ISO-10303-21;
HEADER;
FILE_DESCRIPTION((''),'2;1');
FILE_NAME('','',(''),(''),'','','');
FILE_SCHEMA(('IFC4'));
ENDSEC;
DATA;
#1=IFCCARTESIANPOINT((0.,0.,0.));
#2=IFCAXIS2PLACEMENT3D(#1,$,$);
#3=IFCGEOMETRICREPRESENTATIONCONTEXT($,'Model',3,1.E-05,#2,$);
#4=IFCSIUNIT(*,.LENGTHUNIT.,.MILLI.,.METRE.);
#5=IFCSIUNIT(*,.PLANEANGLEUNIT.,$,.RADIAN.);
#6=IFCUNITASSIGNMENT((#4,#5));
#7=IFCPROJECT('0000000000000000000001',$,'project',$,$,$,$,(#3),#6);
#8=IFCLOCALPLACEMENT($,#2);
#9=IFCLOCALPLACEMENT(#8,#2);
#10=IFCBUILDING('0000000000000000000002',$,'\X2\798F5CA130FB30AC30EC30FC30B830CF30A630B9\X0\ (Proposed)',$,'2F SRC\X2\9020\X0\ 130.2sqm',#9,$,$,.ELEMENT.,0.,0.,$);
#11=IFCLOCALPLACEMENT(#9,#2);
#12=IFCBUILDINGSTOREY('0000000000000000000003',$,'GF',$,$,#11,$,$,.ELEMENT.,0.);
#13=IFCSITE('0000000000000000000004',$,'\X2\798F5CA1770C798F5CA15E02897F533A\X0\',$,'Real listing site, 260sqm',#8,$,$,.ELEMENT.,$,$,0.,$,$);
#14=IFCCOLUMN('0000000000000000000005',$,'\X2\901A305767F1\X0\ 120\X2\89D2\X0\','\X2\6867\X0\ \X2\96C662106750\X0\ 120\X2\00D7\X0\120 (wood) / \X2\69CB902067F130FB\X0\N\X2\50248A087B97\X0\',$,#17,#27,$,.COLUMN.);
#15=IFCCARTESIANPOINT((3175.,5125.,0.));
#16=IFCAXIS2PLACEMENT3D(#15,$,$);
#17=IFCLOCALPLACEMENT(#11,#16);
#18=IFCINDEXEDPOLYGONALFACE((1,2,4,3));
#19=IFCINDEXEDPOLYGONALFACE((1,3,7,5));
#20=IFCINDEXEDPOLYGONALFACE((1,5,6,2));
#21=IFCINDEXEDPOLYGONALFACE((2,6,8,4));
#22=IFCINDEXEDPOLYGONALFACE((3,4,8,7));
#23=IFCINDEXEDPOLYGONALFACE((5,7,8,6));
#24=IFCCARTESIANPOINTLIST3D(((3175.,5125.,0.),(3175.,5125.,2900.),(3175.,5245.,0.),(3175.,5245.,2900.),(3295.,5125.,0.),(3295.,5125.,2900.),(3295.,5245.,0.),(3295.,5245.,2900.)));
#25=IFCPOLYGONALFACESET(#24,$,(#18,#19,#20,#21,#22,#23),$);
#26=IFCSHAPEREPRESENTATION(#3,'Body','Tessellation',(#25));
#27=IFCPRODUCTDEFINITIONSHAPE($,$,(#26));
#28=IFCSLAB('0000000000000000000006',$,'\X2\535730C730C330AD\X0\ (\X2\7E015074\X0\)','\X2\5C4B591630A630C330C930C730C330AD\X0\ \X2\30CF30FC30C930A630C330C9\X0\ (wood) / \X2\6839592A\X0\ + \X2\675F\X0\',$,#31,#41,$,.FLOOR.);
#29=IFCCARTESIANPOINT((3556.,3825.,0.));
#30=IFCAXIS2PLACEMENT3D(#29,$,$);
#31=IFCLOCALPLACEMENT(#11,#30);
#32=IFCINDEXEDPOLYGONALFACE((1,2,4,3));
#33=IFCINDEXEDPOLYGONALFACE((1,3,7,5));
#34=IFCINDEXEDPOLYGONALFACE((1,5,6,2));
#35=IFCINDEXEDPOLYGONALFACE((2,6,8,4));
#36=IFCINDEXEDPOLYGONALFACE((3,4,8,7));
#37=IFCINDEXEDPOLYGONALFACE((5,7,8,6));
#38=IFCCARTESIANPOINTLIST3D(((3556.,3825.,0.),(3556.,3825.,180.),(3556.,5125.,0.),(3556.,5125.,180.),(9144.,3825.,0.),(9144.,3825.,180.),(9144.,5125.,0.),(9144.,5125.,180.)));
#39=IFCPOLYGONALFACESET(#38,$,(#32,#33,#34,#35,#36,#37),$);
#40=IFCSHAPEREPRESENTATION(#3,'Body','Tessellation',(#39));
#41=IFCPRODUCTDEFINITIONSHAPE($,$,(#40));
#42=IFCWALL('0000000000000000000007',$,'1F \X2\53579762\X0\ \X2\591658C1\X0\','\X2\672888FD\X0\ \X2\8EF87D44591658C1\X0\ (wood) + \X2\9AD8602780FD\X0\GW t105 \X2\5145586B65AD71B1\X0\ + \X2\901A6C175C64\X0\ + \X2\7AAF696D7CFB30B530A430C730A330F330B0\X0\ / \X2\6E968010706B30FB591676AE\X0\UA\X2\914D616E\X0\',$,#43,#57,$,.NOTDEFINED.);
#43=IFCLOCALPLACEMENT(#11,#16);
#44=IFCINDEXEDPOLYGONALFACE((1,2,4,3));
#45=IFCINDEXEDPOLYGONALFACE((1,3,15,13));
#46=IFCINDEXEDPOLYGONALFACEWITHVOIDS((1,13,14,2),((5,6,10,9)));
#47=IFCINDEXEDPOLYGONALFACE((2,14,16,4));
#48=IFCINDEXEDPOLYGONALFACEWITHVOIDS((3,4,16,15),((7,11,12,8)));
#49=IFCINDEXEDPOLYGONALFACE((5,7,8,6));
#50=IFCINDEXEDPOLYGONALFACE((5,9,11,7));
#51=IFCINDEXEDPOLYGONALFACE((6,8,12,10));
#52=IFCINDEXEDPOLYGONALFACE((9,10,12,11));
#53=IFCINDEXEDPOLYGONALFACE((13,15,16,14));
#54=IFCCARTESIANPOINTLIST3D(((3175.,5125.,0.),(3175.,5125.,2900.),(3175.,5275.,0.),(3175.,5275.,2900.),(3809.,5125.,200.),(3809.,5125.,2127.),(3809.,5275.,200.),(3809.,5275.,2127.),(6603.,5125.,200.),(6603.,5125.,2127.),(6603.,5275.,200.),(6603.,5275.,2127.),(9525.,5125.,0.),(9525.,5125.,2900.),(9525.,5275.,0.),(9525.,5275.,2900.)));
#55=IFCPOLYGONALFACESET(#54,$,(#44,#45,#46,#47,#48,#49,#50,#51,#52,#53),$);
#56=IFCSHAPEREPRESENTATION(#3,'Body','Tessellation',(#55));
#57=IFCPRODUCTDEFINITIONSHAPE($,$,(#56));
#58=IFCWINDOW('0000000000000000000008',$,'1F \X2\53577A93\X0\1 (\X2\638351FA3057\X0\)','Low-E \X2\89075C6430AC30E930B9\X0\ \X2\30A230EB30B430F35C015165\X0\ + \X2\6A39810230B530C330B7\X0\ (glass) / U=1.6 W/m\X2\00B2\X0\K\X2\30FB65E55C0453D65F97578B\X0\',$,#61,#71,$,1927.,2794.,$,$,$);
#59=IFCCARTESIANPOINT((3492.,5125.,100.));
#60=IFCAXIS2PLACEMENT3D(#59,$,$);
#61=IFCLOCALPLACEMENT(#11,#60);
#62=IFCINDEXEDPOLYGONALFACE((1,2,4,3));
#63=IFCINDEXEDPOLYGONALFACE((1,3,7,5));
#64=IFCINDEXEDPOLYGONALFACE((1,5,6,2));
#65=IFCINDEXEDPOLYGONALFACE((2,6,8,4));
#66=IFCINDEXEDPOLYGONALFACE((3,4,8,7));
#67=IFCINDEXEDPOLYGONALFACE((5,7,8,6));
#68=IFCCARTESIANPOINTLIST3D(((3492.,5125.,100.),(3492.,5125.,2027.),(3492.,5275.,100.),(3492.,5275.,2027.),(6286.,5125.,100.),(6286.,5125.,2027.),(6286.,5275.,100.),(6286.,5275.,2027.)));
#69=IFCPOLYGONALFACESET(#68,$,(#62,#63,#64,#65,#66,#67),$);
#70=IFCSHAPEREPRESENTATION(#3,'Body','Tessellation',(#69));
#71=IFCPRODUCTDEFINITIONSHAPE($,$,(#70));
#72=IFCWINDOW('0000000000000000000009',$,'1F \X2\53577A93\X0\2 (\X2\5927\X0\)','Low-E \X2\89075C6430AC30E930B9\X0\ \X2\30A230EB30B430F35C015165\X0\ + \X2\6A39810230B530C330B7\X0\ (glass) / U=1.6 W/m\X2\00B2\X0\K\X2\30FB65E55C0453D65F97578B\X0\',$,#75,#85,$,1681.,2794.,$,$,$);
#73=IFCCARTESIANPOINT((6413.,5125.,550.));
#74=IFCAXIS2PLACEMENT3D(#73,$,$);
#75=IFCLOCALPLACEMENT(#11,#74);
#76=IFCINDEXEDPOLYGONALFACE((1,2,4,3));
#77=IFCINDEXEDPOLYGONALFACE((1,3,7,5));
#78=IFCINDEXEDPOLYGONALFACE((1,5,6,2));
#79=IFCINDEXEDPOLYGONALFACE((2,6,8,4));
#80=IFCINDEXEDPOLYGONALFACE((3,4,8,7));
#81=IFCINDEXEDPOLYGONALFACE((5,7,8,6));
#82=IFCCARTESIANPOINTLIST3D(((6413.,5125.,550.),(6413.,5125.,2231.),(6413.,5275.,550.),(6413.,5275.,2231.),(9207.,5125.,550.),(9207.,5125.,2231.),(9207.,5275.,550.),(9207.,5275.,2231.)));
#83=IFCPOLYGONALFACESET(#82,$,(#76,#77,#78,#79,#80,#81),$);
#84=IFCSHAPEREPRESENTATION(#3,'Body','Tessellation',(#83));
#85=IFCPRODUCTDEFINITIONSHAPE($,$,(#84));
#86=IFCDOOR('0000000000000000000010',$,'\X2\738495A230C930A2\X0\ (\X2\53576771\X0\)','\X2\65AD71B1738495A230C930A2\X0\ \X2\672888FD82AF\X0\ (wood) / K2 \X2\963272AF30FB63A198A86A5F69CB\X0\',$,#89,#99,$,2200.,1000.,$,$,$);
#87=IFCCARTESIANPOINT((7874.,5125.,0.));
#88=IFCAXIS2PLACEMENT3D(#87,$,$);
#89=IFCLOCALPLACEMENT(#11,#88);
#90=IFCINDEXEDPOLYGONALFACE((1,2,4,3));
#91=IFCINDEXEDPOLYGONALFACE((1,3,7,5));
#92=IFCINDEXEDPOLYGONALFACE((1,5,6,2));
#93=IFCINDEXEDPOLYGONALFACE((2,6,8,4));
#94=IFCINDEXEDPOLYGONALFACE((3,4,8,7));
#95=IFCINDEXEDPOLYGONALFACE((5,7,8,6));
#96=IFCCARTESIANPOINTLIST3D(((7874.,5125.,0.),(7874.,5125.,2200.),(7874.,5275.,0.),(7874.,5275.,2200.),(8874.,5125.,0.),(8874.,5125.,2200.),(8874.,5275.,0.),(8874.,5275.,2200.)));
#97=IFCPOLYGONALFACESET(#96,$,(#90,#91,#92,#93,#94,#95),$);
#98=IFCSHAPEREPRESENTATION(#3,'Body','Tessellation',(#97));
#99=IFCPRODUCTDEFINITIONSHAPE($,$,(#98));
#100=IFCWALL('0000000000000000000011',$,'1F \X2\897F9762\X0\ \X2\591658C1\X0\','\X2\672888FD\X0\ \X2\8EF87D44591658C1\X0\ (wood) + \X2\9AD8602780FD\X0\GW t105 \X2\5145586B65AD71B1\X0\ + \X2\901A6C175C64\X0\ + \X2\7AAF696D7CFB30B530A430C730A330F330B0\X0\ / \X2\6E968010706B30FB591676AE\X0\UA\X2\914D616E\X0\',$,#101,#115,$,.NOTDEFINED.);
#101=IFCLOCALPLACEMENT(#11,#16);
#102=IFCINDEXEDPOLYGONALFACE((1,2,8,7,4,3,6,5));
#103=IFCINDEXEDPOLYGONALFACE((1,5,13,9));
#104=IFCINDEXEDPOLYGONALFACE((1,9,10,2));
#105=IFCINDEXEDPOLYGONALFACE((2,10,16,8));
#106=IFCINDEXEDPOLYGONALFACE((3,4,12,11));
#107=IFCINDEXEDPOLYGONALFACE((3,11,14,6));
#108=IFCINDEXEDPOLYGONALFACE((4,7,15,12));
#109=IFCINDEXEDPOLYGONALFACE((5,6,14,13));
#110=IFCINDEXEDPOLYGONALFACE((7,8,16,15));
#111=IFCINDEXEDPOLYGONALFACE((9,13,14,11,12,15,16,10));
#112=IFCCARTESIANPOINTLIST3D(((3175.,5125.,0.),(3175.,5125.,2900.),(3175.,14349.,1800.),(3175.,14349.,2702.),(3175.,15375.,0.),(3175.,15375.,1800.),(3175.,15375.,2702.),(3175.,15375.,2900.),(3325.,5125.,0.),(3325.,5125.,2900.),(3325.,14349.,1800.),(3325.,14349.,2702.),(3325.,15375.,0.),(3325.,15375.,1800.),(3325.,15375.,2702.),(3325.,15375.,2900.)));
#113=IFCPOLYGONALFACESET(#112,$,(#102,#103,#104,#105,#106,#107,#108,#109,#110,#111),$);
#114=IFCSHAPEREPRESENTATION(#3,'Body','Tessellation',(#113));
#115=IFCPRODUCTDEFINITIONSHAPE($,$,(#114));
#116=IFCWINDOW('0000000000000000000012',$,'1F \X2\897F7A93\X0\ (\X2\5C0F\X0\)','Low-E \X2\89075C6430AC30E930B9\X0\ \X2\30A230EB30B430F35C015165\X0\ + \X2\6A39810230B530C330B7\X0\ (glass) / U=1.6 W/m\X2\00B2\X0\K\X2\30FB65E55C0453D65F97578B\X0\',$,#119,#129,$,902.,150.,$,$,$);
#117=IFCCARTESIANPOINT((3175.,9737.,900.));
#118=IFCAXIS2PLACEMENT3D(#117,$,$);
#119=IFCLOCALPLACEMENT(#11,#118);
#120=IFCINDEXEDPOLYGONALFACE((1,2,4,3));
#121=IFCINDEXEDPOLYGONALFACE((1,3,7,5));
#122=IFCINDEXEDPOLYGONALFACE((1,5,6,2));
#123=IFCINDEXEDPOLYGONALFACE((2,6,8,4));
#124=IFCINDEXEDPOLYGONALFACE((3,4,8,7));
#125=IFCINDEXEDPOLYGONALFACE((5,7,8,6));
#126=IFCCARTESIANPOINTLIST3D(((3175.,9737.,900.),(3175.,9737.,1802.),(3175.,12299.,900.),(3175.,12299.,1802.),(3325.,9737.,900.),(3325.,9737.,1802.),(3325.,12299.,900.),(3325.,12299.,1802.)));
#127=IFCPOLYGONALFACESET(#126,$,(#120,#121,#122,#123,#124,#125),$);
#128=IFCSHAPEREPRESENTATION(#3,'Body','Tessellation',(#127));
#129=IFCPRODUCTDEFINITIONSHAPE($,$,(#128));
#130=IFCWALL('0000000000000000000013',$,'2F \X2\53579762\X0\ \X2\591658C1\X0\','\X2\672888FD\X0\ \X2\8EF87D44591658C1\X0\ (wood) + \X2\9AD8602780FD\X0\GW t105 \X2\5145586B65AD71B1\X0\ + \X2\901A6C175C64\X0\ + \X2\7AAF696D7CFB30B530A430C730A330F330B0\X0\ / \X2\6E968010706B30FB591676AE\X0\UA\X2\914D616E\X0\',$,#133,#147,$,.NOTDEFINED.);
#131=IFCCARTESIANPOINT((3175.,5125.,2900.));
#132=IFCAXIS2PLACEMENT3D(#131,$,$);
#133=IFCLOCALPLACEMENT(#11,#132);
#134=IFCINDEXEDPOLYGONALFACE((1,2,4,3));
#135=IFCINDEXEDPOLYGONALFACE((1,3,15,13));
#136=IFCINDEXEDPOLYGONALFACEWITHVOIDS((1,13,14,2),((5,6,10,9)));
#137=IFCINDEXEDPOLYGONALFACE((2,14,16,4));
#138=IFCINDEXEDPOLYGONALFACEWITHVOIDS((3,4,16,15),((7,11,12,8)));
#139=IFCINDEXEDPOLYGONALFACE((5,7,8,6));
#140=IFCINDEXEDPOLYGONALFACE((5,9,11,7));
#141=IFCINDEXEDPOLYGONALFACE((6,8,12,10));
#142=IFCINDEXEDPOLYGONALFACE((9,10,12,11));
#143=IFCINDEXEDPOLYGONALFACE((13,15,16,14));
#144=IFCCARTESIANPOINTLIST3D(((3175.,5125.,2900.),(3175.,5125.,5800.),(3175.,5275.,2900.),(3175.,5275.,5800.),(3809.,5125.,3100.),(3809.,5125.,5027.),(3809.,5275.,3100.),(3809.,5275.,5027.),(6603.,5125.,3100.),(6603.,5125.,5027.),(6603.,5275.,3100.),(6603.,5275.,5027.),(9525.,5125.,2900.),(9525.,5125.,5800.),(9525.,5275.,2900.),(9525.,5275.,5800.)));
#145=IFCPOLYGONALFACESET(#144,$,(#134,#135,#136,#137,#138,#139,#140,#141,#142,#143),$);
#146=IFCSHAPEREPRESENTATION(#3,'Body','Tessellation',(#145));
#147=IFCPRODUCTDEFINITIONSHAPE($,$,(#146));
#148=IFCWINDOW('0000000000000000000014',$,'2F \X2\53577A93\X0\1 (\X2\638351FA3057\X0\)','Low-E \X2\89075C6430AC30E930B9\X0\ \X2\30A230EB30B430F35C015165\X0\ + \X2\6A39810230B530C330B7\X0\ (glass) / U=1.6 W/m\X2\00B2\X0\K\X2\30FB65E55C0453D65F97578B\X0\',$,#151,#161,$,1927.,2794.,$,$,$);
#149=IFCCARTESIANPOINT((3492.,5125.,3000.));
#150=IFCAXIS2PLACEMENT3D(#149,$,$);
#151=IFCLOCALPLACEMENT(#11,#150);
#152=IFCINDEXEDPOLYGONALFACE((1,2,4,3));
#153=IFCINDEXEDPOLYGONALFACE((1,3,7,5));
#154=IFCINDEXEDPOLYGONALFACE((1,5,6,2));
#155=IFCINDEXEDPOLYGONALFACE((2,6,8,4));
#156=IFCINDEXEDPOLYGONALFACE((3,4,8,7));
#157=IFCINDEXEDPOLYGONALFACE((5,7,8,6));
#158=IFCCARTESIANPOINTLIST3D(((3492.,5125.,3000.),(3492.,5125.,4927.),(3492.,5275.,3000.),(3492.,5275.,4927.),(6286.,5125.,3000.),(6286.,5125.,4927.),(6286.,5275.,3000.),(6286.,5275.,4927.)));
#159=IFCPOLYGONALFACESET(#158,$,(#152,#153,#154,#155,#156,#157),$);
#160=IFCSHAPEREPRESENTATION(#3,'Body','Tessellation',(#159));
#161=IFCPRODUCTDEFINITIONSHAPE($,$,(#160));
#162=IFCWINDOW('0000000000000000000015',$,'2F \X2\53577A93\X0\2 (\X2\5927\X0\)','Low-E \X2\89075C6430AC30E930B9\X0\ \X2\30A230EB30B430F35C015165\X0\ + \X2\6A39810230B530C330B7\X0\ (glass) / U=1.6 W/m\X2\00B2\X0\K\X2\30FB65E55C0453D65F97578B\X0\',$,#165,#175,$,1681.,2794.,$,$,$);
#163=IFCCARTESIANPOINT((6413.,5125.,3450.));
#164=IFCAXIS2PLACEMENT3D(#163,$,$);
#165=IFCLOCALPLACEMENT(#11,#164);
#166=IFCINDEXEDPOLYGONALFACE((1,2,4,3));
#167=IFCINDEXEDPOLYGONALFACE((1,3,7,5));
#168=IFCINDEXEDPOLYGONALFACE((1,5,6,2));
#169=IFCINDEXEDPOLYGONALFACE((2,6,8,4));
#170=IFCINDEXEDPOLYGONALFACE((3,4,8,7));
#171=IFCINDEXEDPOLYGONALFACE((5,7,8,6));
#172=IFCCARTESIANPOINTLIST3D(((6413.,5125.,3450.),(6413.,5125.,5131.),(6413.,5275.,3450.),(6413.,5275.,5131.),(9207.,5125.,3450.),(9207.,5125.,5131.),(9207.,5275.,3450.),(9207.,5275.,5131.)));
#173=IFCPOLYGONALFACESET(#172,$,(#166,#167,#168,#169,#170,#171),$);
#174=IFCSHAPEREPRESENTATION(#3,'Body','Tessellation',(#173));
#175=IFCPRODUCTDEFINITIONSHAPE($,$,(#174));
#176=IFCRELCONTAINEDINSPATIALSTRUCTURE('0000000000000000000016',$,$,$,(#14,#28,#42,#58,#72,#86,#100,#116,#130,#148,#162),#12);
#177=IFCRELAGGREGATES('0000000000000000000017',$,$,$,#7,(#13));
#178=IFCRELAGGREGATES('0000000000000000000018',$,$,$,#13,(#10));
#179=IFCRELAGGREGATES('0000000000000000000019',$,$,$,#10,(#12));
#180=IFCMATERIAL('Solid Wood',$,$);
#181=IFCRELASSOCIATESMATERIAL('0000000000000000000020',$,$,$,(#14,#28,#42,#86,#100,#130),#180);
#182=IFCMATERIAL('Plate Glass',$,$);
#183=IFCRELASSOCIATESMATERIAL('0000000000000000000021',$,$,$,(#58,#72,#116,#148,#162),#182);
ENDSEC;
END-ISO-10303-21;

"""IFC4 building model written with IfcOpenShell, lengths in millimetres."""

from ifc_helpers import new_model, si_unit, frame, frame_2d, origin, place, context, project, spatial, rectangle, extrude, material, element, fill, save


model = new_model("IFC4")

# Units and contexts
model_context = context("Model", 3, precision=1e-05, world=origin())
ifc_project = project(units=[si_unit("LENGTHUNIT", "METRE", prefix="MILLI"), si_unit("PLANEANGLEUNIT", "RADIAN")], contexts=[model_context])

# Site, building, storey
site_placement = place(None, origin())
site = spatial("IfcSite", under=ifc_project, at=site_placement, Name="福岡県福岡市西区", ObjectType="Real listing site, 260sqm", CompositionType="ELEMENT", RefElevation=0.0)
building_placement = place(site_placement, origin())
building = spatial("IfcBuilding", under=site, at=building_placement, Name="福岡・ガレージハウス (Proposed)", ObjectType="2F SRC造 130.2sqm", CompositionType="ELEMENT", ElevationOfRefHeight=0.0, ElevationOfTerrain=0.0)
storey_placement = place(building_placement, origin())
storey = spatial("IfcBuildingStorey", under=building, at=storey_placement, Name="GF", CompositionType="ELEMENT", Elevation=0.0)

# Column
ifc_material_1 = material(Name="Solid Wood")
column_placement = place(storey_placement, frame((3175.0, 5125.0, 0.0)))
element("IfcColumn", 1, at=column_placement, inside=storey, material=ifc_material_1, Name="通し柱 120角", Description="桧 集成材 120×120 (wood) / 構造柱・N値計算", PredefinedType="COLUMN", context=model_context, shape_type="SweptSolid", body=[
    extrude(rectangle(XDim=120.0, YDim=120.0, at=frame_2d((60.0, 60.0))), frame((3175.0, 5125.0, 0.0)), (0.0, 0.0, 1.0), 2900.0),
])

# Slab
slab_1_placement = place(storey_placement, frame((3556.0, 3825.0, 0.0)))
element("IfcSlab", 2, at=slab_1_placement, inside=storey, material=ifc_material_1, Name="南デッキ (縁側)", Description="屋外ウッドデッキ ハードウッド (wood) / 根太 + 束", PredefinedType="FLOOR", context=model_context, shape_type="SweptSolid", body=[
    extrude(rectangle(XDim=5588.0, YDim=1300.0, at=frame_2d((2794.0, 650.0))), frame((3556.0, 3825.0, 0.0)), (0.0, 0.0, 1.0), 180.0),
])

# Wall, openings, windows, door
wall_1_placement = place(storey_placement, frame((3175.0, 5125.0, 0.0)))
wall_1 = element("IfcWall", 3, at=wall_1_placement, inside=storey, material=ifc_material_1, Name="1F 南面 外壁", Description="木製 軸組外壁 (wood) + 高性能GW t105 充填断熱 + 通気層 + 窯業系サイディング / 準耐火・外皮UA配慮", PredefinedType="NOTDEFINED", context=model_context, shape_type="SweptSolid", body=[
    extrude(rectangle(XDim=6350.0, YDim=150.0, at=frame_2d((3175.0, 75.0))), frame((3175.0, 5125.0, 0.0)), (0.0, 0.0, 1.0), 2900.0),
])
opening_1_placement = place(storey_placement, frame((3492.0, 5125.0, 100.0)))
opening_1 = element("IfcOpeningElement", 4, at=opening_1_placement, cuts=wall_1, PredefinedType="NOTDEFINED", context=model_context, shape_type="SweptSolid", body=[
    extrude(rectangle(XDim=2794.0, YDim=150.0, at=frame_2d((1397.0, 75.0))), frame((3492.0, 5125.0, 100.0)), (0.0, 0.0, 1.0), 1927.0),
])
opening_2_placement = place(storey_placement, frame((6413.0, 5125.0, 550.0)))
opening_2 = element("IfcOpeningElement", 5, at=opening_2_placement, cuts=wall_1, PredefinedType="NOTDEFINED", context=model_context, shape_type="SweptSolid", body=[
    extrude(rectangle(XDim=2794.0, YDim=150.0, at=frame_2d((1397.0, 75.0))), frame((6413.0, 5125.0, 550.0)), (0.0, 0.0, 1.0), 1681.0),
])
opening_3_placement = place(storey_placement, frame((7874.0, 5125.0, 0.0)))
opening_3 = element("IfcOpeningElement", 6, at=opening_3_placement, cuts=wall_1, PredefinedType="NOTDEFINED", context=model_context, shape_type="SweptSolid", body=[
    extrude(rectangle(XDim=1000.0, YDim=150.0, at=frame_2d((500.0, 75.0))), frame((7874.0, 5125.0, 0.0)), (0.0, 0.0, 1.0), 2200.0),
])
ifc_material_2 = material(Name="Plate Glass")
window_1_placement = place(storey_placement, frame((3492.0, 5125.0, 100.0)))
window_1 = element("IfcWindow", 7, at=window_1_placement, inside=storey, material=ifc_material_2, Name="1F 南窓1 (掃出し)", Description="Low-E 複層ガラス アルゴン封入 + 樹脂サッシ (glass) / U=1.6 W/m²K・日射取得型", OverallHeight=1927.0, OverallWidth=2794.0, context=model_context, shape_type="SweptSolid", body=[
    extrude(rectangle(XDim=2794.0, YDim=150.0, at=frame_2d((1397.0, 75.0))), frame((3492.0, 5125.0, 100.0)), (0.0, 0.0, 1.0), 1927.0),
])
fill(opening_1, window_1)
window_2_placement = place(storey_placement, frame((6413.0, 5125.0, 550.0)))
window_2 = element("IfcWindow", 8, at=window_2_placement, inside=storey, material=ifc_material_2, Name="1F 南窓2 (大)", Description="Low-E 複層ガラス アルゴン封入 + 樹脂サッシ (glass) / U=1.6 W/m²K・日射取得型", OverallHeight=1681.0, OverallWidth=2794.0, context=model_context, shape_type="SweptSolid", body=[
    extrude(rectangle(XDim=2794.0, YDim=150.0, at=frame_2d((1397.0, 75.0))), frame((6413.0, 5125.0, 550.0)), (0.0, 0.0, 1.0), 1681.0),
])
fill(opening_2, window_2)
door_placement = place(storey_placement, frame((7874.0, 5125.0, 0.0)))
door = element("IfcDoor", 9, at=door_placement, inside=storey, material=ifc_material_1, Name="玄関ドア (南東)", Description="断熱玄関ドア 木製芯 (wood) / K2 防犯・採風機構", OverallHeight=2200.0, OverallWidth=1000.0, context=model_context, shape_type="SweptSolid", body=[
    extrude(rectangle(XDim=1000.0, YDim=150.0, at=frame_2d((500.0, 75.0))), frame((7874.0, 5125.0, 0.0)), (0.0, 0.0, 1.0), 2200.0),
])
fill(opening_3, door)

# Wall, opening, window
wall_2_placement = place(storey_placement, frame((3175.0, 5125.0, 0.0)))
wall_2 = element("IfcWall", 10, at=wall_2_placement, inside=storey, material=ifc_material_1, Name="1F 西面 外壁", Description="木製 軸組外壁 (wood) + 高性能GW t105 充填断熱 + 通気層 + 窯業系サイディング / 準耐火・外皮UA配慮", PredefinedType="NOTDEFINED", context=model_context, shape_type="SweptSolid", body=[
    extrude(rectangle(XDim=150.0, YDim=10250.0, at=frame_2d((75.0, 5125.0))), frame((3175.0, 5125.0, 0.0)), (0.0, 0.0, 1.0), 2900.0),
])
opening_4_placement = place(storey_placement, frame((3175.0, 9737.0, 900.0)))
opening_4 = element("IfcOpeningElement", 11, at=opening_4_placement, cuts=wall_2, PredefinedType="NOTDEFINED", context=model_context, shape_type="SweptSolid", body=[
    extrude(rectangle(XDim=150.0, YDim=2562.0, at=frame_2d((75.0, 1281.0))), frame((3175.0, 9737.0, 900.0)), (0.0, 0.0, 1.0), 902.0),
])
window_3_placement = place(storey_placement, frame((3175.0, 9737.0, 900.0)))
window_3 = element("IfcWindow", 12, at=window_3_placement, inside=storey, material=ifc_material_2, Name="1F 西窓 (小)", Description="Low-E 複層ガラス アルゴン封入 + 樹脂サッシ (glass) / U=1.6 W/m²K・日射取得型", OverallHeight=902.0, OverallWidth=150.0, context=model_context, shape_type="SweptSolid", body=[
    extrude(rectangle(XDim=150.0, YDim=2562.0, at=frame_2d((75.0, 1281.0))), frame((3175.0, 9737.0, 900.0)), (0.0, 0.0, 1.0), 902.0),
])
fill(opening_4, window_3)

# Wall, openings, windows
wall_3_placement = place(storey_placement, frame((3175.0, 5125.0, 2900.0)))
wall_3 = element("IfcWall", 13, at=wall_3_placement, inside=storey, material=ifc_material_1, Name="2F 南面 外壁", Description="木製 軸組外壁 (wood) + 高性能GW t105 充填断熱 + 通気層 + 窯業系サイディング / 準耐火・外皮UA配慮", PredefinedType="NOTDEFINED", context=model_context, shape_type="SweptSolid", body=[
    extrude(rectangle(XDim=6350.0, YDim=150.0, at=frame_2d((3175.0, 75.0))), frame((3175.0, 5125.0, 2900.0)), (0.0, 0.0, 1.0), 2900.0),
])
opening_5_placement = place(storey_placement, frame((3492.0, 5125.0, 3000.0)))
opening_5 = element("IfcOpeningElement", 14, at=opening_5_placement, cuts=wall_3, PredefinedType="NOTDEFINED", context=model_context, shape_type="SweptSolid", body=[
    extrude(rectangle(XDim=2794.0, YDim=150.0, at=frame_2d((1397.0, 75.0))), frame((3492.0, 5125.0, 3000.0)), (0.0, 0.0, 1.0), 1927.0),
])
opening_6_placement = place(storey_placement, frame((6413.0, 5125.0, 3450.0)))
opening_6 = element("IfcOpeningElement", 15, at=opening_6_placement, cuts=wall_3, PredefinedType="NOTDEFINED", context=model_context, shape_type="SweptSolid", body=[
    extrude(rectangle(XDim=2794.0, YDim=150.0, at=frame_2d((1397.0, 75.0))), frame((6413.0, 5125.0, 3450.0)), (0.0, 0.0, 1.0), 1681.0),
])
window_4_placement = place(storey_placement, frame((3492.0, 5125.0, 3000.0)))
window_4 = element("IfcWindow", 16, at=window_4_placement, inside=storey, material=ifc_material_2, Name="2F 南窓1 (掃出し)", Description="Low-E 複層ガラス アルゴン封入 + 樹脂サッシ (glass) / U=1.6 W/m²K・日射取得型", OverallHeight=1927.0, OverallWidth=2794.0, context=model_context, shape_type="SweptSolid", body=[
    extrude(rectangle(XDim=2794.0, YDim=150.0, at=frame_2d((1397.0, 75.0))), frame((3492.0, 5125.0, 3000.0)), (0.0, 0.0, 1.0), 1927.0),
])
fill(opening_5, window_4)
window_5_placement = place(storey_placement, frame((6413.0, 5125.0, 3450.0)))
window_5 = element("IfcWindow", 17, at=window_5_placement, inside=storey, material=ifc_material_2, Name="2F 南窓2 (大)", Description="Low-E 複層ガラス アルゴン封入 + 樹脂サッシ (glass) / U=1.6 W/m²K・日射取得型", OverallHeight=1681.0, OverallWidth=2794.0, context=model_context, shape_type="SweptSolid", body=[
    extrude(rectangle(XDim=2794.0, YDim=150.0, at=frame_2d((1397.0, 75.0))), frame((6413.0, 5125.0, 3450.0)), (0.0, 0.0, 1.0), 1681.0),
])
fill(opening_6, window_5)

save(model, "model.ifc")
